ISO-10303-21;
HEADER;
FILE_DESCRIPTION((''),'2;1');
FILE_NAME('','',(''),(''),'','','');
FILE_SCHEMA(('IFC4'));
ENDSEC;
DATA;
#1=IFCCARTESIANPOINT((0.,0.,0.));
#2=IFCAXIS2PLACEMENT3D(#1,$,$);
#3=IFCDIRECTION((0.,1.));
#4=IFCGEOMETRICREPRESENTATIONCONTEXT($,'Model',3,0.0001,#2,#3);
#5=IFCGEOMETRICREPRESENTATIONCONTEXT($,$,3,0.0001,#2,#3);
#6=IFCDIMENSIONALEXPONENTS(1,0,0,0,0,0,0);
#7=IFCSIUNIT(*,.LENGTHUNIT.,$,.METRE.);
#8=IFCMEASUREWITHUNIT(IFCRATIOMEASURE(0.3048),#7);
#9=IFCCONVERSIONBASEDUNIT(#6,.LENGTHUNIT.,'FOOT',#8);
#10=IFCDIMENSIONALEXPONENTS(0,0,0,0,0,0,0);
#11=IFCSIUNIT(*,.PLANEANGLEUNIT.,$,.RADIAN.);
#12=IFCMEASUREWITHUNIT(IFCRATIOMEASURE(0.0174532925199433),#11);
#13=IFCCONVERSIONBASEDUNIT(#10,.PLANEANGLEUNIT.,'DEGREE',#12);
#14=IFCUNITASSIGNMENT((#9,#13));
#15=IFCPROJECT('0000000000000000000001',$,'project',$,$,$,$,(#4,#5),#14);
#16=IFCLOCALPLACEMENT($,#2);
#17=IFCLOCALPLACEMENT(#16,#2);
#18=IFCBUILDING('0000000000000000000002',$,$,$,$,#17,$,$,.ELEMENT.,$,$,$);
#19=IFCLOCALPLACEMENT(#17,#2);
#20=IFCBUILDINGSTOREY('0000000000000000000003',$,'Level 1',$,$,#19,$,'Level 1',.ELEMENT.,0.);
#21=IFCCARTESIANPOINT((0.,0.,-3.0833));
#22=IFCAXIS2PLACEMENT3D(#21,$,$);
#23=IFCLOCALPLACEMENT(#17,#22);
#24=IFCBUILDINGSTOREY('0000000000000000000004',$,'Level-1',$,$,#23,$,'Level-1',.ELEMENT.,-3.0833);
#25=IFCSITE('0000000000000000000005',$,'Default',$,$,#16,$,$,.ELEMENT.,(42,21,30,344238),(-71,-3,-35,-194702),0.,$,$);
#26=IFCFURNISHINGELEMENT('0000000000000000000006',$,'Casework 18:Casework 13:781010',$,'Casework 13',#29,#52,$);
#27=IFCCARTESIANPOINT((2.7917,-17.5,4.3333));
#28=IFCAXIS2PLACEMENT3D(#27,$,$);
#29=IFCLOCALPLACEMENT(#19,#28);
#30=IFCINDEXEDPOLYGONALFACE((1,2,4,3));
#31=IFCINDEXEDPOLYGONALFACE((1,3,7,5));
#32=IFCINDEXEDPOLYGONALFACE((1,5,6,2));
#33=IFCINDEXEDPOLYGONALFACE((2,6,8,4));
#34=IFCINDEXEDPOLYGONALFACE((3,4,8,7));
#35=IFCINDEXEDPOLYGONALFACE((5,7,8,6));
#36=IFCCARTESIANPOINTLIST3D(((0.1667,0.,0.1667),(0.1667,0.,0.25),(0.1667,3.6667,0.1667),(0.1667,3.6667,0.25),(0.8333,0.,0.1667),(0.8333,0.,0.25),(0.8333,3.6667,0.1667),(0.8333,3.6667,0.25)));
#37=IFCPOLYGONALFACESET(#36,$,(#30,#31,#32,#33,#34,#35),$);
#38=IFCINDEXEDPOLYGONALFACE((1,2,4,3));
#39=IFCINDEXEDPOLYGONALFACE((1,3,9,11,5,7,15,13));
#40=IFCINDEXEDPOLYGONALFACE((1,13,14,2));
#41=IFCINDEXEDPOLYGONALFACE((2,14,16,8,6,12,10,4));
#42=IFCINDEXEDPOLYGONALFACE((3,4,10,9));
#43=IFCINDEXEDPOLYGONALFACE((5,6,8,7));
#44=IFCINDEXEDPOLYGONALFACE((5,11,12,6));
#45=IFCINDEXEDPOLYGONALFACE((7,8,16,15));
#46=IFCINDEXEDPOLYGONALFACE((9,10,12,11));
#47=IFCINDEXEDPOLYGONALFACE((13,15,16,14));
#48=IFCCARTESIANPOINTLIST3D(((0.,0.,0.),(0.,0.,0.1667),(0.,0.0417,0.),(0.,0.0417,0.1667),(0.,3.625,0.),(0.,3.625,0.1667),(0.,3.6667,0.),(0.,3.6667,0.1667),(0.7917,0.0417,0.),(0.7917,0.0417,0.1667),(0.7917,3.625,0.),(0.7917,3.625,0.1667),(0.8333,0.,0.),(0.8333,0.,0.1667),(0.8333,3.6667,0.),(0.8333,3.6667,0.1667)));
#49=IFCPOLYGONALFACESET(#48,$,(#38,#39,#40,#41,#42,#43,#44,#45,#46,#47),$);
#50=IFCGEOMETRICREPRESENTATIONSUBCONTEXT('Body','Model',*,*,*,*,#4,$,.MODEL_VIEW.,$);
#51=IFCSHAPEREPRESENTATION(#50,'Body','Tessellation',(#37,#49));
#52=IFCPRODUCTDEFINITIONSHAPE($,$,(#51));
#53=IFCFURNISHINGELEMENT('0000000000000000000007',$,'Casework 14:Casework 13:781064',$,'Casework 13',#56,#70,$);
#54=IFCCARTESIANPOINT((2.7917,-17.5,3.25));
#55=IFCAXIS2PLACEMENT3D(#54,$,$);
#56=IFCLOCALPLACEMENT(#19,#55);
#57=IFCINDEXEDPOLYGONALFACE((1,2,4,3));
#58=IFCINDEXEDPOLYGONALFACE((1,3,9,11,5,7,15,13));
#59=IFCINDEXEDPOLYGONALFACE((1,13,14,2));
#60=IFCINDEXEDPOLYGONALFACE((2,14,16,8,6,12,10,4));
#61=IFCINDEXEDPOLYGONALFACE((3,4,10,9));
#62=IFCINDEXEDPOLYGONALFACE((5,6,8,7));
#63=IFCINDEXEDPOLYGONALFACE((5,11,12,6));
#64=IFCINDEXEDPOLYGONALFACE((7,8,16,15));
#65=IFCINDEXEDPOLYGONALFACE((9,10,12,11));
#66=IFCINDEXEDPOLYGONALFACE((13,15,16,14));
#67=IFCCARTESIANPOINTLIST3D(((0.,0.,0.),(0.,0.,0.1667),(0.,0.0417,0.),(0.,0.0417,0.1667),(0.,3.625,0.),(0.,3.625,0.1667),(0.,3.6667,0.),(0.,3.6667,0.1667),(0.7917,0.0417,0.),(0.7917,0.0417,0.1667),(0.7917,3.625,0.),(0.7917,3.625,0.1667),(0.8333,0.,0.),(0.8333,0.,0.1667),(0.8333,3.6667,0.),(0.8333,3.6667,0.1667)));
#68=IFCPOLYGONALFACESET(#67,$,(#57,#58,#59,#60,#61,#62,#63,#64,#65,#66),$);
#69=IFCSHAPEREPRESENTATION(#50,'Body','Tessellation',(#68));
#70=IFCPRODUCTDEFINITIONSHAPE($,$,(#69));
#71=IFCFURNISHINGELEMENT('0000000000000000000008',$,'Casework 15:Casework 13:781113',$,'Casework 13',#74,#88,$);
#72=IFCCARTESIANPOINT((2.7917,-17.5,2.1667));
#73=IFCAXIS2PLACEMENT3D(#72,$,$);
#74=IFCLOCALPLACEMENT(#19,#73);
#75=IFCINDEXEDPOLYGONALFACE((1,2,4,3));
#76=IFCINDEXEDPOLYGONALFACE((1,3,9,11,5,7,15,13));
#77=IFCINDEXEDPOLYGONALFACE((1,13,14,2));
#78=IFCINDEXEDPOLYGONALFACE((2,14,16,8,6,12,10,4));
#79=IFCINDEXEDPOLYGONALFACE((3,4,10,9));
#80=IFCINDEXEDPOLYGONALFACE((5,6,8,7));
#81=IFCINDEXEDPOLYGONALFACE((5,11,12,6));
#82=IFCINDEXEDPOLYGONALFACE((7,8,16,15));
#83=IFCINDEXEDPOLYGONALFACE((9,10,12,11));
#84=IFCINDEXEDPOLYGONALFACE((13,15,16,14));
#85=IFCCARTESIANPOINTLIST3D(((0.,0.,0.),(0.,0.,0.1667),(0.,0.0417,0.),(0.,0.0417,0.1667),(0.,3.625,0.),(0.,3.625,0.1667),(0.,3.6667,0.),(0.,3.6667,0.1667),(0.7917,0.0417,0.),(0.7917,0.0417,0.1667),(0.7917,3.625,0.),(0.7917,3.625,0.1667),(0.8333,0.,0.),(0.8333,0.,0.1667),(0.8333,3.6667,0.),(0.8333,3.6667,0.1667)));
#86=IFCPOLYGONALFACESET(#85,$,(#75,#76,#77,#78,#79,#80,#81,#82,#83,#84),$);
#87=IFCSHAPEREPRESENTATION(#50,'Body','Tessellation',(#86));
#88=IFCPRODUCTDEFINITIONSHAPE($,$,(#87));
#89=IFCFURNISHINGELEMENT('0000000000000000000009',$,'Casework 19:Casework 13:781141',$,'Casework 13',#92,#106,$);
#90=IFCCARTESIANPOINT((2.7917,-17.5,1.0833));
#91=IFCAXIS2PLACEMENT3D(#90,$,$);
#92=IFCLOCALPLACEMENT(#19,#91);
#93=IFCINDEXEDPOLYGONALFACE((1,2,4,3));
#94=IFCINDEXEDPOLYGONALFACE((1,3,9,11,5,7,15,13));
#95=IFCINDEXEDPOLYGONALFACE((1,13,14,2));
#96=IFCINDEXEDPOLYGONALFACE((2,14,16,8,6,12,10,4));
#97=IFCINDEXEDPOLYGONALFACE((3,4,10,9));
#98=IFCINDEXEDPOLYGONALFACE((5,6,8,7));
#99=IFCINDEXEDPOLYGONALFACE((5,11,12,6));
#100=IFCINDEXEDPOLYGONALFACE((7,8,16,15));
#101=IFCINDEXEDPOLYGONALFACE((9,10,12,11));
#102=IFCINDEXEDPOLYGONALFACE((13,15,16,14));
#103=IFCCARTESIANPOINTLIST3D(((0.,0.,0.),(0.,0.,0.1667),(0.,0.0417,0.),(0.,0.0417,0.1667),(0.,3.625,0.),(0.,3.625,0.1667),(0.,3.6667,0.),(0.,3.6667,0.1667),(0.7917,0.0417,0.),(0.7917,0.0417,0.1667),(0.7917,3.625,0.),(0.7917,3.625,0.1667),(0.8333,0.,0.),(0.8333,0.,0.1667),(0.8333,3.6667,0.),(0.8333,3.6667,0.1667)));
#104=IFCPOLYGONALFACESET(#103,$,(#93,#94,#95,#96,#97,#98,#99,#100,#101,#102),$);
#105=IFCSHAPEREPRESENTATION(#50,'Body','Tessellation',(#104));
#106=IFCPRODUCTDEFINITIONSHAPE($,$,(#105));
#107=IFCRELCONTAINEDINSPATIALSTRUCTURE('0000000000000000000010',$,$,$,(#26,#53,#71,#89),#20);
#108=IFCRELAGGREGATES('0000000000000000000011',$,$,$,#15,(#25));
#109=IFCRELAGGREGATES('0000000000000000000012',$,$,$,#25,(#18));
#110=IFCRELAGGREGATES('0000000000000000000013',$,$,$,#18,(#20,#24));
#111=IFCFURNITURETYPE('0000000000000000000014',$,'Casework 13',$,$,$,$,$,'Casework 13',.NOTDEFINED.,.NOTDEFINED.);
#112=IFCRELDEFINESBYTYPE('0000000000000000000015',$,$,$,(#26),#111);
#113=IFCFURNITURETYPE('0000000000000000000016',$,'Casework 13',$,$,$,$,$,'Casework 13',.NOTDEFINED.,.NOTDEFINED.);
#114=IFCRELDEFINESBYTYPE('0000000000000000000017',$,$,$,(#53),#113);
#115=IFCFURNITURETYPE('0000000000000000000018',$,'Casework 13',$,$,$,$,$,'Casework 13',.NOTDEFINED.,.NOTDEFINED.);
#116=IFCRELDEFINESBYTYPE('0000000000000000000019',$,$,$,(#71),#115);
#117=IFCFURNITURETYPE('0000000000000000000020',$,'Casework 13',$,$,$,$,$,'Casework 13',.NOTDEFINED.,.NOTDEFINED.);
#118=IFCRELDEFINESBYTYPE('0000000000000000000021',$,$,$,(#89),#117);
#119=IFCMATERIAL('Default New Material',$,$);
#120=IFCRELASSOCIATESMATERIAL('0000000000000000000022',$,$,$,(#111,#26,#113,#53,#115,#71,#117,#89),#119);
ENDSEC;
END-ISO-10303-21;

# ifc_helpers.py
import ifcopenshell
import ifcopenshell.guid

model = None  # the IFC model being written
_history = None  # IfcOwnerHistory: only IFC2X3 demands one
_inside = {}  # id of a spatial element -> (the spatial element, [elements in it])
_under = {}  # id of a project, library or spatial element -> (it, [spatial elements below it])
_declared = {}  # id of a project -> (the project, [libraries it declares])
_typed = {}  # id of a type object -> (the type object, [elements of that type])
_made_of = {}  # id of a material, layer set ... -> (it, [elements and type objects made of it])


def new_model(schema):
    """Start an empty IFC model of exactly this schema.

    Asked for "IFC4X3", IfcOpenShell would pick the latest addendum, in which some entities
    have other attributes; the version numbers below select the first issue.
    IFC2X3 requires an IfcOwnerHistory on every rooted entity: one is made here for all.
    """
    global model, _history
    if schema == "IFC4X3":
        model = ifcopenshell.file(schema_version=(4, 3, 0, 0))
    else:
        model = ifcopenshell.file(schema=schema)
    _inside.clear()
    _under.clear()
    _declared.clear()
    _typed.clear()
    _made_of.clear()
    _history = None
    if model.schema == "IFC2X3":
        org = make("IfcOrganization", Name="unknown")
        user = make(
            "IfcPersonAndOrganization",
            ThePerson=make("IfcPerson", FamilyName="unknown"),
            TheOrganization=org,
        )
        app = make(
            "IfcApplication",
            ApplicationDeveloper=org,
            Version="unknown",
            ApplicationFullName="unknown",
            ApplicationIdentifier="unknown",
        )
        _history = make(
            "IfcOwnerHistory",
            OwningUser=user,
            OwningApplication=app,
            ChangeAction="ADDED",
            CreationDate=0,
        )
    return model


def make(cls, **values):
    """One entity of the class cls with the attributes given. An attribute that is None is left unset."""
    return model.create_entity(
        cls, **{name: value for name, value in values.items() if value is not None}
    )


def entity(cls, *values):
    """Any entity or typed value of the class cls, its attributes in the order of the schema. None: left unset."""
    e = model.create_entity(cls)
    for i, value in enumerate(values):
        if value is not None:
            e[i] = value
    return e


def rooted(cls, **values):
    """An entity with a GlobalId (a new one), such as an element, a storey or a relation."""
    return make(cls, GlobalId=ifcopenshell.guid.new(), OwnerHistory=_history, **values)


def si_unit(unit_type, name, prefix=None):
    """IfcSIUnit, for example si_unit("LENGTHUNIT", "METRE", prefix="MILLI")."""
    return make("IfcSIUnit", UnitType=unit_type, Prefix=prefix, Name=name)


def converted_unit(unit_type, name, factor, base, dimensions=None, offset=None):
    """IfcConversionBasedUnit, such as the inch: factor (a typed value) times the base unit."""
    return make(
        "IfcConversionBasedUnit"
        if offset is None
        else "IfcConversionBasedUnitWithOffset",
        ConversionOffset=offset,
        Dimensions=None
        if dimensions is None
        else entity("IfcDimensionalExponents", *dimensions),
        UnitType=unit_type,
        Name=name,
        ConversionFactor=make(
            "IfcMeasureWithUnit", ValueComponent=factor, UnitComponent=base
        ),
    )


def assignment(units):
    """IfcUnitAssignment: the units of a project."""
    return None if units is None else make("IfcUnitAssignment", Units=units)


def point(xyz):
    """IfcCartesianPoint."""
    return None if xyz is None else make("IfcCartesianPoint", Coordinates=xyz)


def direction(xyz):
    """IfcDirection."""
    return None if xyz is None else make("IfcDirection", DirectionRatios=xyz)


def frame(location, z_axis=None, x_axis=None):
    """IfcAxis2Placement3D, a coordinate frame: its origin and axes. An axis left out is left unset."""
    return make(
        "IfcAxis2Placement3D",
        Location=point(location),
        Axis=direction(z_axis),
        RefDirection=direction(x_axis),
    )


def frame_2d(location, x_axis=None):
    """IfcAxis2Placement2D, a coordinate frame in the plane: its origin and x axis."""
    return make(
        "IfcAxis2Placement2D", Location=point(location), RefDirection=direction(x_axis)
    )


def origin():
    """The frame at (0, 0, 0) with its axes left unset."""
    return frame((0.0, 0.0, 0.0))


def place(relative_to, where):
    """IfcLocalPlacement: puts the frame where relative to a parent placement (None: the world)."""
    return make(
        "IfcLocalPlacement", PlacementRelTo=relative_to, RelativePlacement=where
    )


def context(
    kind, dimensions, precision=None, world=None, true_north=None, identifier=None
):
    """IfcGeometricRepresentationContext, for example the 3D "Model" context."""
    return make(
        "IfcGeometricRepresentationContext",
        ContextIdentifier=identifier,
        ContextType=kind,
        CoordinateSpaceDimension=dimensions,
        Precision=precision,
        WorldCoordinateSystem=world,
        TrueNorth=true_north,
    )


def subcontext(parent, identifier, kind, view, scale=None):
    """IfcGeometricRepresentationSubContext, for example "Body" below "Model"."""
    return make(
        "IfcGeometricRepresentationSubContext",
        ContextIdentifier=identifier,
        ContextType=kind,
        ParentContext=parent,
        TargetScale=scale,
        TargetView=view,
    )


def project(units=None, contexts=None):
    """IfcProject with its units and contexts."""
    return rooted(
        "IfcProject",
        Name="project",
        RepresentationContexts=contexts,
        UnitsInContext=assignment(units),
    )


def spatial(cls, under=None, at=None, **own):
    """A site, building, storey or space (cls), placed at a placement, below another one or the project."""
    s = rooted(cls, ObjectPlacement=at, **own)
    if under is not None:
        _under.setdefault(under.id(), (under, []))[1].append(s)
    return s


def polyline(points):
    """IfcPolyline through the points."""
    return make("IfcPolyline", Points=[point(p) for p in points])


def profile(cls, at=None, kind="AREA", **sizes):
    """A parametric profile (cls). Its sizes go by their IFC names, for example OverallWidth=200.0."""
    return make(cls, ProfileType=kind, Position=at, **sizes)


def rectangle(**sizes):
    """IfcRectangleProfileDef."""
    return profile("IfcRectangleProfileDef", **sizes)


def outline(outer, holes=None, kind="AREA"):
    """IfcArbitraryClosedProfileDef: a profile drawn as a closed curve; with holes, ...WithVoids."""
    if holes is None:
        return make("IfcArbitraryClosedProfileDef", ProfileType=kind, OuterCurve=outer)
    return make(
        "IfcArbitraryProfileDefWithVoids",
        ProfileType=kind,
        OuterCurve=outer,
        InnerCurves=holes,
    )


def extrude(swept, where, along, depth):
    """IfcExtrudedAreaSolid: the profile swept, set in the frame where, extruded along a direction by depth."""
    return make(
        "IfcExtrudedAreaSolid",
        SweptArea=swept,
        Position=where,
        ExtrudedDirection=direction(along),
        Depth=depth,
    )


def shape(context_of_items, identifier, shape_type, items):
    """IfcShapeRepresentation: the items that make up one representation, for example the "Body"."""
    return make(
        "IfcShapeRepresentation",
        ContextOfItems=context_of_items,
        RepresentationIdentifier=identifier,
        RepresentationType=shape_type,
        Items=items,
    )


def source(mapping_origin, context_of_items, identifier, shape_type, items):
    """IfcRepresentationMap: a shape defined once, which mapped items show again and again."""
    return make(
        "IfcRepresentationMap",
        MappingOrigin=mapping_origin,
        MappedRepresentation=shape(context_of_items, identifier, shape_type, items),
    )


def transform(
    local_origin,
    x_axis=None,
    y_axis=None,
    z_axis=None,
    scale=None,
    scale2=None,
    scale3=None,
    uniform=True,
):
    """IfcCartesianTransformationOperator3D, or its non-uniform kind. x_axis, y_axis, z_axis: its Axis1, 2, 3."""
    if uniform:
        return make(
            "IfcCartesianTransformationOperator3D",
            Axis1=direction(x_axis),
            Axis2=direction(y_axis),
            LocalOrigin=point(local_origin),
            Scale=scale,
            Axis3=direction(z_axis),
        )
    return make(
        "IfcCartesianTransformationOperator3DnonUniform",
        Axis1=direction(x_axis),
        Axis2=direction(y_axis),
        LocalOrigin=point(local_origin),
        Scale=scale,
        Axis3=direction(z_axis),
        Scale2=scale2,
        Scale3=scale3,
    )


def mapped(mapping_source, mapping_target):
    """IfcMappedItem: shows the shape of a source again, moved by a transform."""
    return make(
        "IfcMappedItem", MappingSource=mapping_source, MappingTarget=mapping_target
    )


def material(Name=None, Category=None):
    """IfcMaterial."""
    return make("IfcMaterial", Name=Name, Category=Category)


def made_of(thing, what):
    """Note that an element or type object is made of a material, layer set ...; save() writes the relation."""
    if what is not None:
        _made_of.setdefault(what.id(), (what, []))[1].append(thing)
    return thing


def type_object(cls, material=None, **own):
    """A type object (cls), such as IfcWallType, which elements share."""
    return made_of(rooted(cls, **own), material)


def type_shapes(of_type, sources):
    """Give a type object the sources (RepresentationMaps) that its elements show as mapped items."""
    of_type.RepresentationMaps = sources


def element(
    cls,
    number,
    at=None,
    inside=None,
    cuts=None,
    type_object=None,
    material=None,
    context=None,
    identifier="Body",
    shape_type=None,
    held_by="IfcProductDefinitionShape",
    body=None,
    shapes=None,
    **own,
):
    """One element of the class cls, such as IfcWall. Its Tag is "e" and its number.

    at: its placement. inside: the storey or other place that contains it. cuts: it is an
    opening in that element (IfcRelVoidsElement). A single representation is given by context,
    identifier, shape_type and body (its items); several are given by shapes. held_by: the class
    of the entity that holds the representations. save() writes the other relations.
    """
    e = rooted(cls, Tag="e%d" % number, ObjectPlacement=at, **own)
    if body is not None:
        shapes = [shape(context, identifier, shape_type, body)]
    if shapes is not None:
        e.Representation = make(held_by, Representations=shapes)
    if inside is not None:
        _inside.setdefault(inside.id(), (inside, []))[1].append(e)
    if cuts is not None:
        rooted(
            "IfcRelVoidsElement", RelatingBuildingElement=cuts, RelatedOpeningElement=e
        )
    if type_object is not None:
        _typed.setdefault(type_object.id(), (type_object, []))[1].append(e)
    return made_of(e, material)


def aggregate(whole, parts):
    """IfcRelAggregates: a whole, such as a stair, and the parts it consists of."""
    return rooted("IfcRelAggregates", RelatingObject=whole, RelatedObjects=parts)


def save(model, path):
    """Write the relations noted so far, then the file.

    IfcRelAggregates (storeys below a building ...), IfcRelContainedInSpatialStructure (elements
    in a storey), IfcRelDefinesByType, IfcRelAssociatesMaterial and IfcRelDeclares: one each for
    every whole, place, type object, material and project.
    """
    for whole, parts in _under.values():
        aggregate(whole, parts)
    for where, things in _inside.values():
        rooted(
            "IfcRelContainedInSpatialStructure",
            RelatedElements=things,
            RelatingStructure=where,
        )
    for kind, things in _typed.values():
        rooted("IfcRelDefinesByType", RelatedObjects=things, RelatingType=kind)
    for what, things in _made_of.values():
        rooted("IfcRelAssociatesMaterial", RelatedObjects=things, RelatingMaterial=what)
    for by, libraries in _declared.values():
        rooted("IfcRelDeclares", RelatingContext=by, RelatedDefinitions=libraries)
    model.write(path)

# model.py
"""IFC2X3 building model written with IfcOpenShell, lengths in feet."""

from ifc_helpers import new_model, entity, si_unit, converted_unit, direction, frame, frame_2d, origin, place, context, subcontext, project, spatial, polyline, rectangle, outline, extrude, source, transform, mapped, material, type_object, type_shapes, element, save


model = new_model("IFC2X3")

# Units and contexts
model_context = context("Model", 3, precision=0.0001, world=origin(), true_north=direction((0.0, 1.0)))
context_of_model = context(None, 3, precision=0.0001, world=origin(), true_north=direction((0.0, 1.0)))
body_context = subcontext(model_context, "Body", "Model", "MODEL_VIEW")
ifc_project = project(units=[converted_unit("LENGTHUNIT", "FOOT", entity("IfcRatioMeasure", 0.3048), si_unit("LENGTHUNIT", "METRE"), dimensions=[1, 0, 0, 0, 0, 0, 0]), converted_unit("PLANEANGLEUNIT", "DEGREE", entity("IfcRatioMeasure", 0.0174532925199433), si_unit("PLANEANGLEUNIT", "RADIAN"), dimensions=[0, 0, 0, 0, 0, 0, 0])], contexts=[model_context, context_of_model])

# Site, building, storey
site_placement = place(None, origin())
site = spatial("IfcSite", under=ifc_project, at=site_placement, Name="Default", CompositionType="ELEMENT", RefLatitude=(42, 21, 30, 344238), RefLongitude=(-71, -3, -35, -194702), RefElevation=0.0)
building_placement = place(site_placement, origin())
building = spatial("IfcBuilding", under=site, at=building_placement, CompositionType="ELEMENT")
storey_1_placement = place(building_placement, origin())
storey_1 = spatial("IfcBuildingStorey", under=building, at=storey_1_placement, Name="Level 1", LongName="Level 1", CompositionType="ELEMENT", Elevation=0.0)

# Shared definitions
ifc_material_1 = material(Name="Default New Material")

# Shared definitions
storey_2_placement = place(building_placement, frame((0.0, 0.0, -3.0833)))
storey_2 = spatial("IfcBuildingStorey", under=building, at=storey_2_placement, Name="Level-1", LongName="Level-1", CompositionType="ELEMENT", Elevation=-3.0833)

# Furnishing elements
furniture_type_1 = type_object("IfcFurnitureType", Name="Casework 13", ElementType="Casework 13", AssemblyPlace="NOTDEFINED", material=ifc_material_1)
shared_shape_1 = source(origin(), body_context, "Body", "SweptSolid", [
    extrude(rectangle(XDim=0.6667, YDim=3.6667, at=frame_2d((0.0, 0.0), x_axis=(1.0, 0.0))), frame((0.5, 1.8333, 0.1667)), (0.0, 0.0, 1.0), 0.0833),
    extrude(outline(polyline([(-0.4063, -1.7917), (-0.4063, -1.8333), (0.4271, -1.8333), (0.4271, 1.8333), (-0.4062, 1.8333), (-0.4062, 1.7917), (0.3854, 1.7917), (0.3854, -1.7917), (-0.4063, -1.7917)])), frame((0.4063, 1.8333, 0.0), z_axis=(0.0, 0.0, -1.0), x_axis=(1.0, 0.0, 0.0)), (0.0, 0.0, -1.0), 0.1667),
])
type_shapes(furniture_type_1, [shared_shape_1])
furnishing_1_placement = place(storey_1_placement, frame((2.7917, -17.5, 4.3333)))
element("IfcFurnishingElement", 1, at=furnishing_1_placement, inside=storey_1, type_object=furniture_type_1, material=ifc_material_1, Name="Casework 18:Casework 13:781010", ObjectType="Casework 13", context=body_context, shape_type="MappedRepresentation", body=[
    mapped(shared_shape_1, transform((0.0, 0.0, 0.0), scale=1.0)),
])
furniture_type_2 = type_object("IfcFurnitureType", Name="Casework 13", ElementType="Casework 13", AssemblyPlace="NOTDEFINED", material=ifc_material_1)
shared_shape_2 = source(origin(), body_context, "Body", "SweptSolid", [
    extrude(outline(polyline([(-0.4063, -1.7917), (-0.4063, -1.8333), (0.4271, -1.8333), (0.4271, 1.8333), (-0.4062, 1.8333), (-0.4062, 1.7917), (0.3854, 1.7917), (0.3854, -1.7917), (-0.4063, -1.7917)])), frame((0.4062, 1.8333, 0.0), z_axis=(0.0, 0.0, -1.0), x_axis=(1.0, 0.0, 0.0)), (0.0, 0.0, -1.0), 0.1667),
])
type_shapes(furniture_type_2, [shared_shape_2])
furnishing_2_placement = place(storey_1_placement, frame((2.7917, -17.5, 3.25)))
element("IfcFurnishingElement", 2, at=furnishing_2_placement, inside=storey_1, type_object=furniture_type_2, material=ifc_material_1, Name="Casework 14:Casework 13:781064", ObjectType="Casework 13", context=body_context, shape_type="MappedRepresentation", body=[
    mapped(shared_shape_2, transform((0.0, 0.0, 0.0), scale=1.0)),
])
furniture_type_3 = type_object("IfcFurnitureType", Name="Casework 13", ElementType="Casework 13", AssemblyPlace="NOTDEFINED", material=ifc_material_1)
shared_shape_3 = source(origin(), body_context, "Body", "SweptSolid", [
    extrude(outline(polyline([(-0.4063, -1.7917), (-0.4063, -1.8333), (0.4271, -1.8333), (0.4271, 1.8333), (-0.4062, 1.8333), (-0.4062, 1.7917), (0.3854, 1.7917), (0.3854, -1.7917), (-0.4063, -1.7917)])), frame((0.4062, 1.8333, 0.0), z_axis=(0.0, 0.0, -1.0), x_axis=(1.0, 0.0, 0.0)), (0.0, 0.0, -1.0), 0.1667),
])
type_shapes(furniture_type_3, [shared_shape_3])
furnishing_3_placement = place(storey_1_placement, frame((2.7917, -17.5, 2.1667)))
element("IfcFurnishingElement", 3, at=furnishing_3_placement, inside=storey_1, type_object=furniture_type_3, material=ifc_material_1, Name="Casework 15:Casework 13:781113", ObjectType="Casework 13", context=body_context, shape_type="MappedRepresentation", body=[
    mapped(shared_shape_3, transform((0.0, 0.0, 0.0), scale=1.0)),
])
furniture_type_4 = type_object("IfcFurnitureType", Name="Casework 13", ElementType="Casework 13", AssemblyPlace="NOTDEFINED", material=ifc_material_1)
shared_shape_4 = source(origin(), body_context, "Body", "SweptSolid", [
    extrude(outline(polyline([(-0.4063, -1.7917), (-0.4063, -1.8333), (0.4271, -1.8333), (0.4271, 1.8333), (-0.4062, 1.8333), (-0.4062, 1.7917), (0.3854, 1.7917), (0.3854, -1.7917), (-0.4063, -1.7917)])), frame((0.4062, 1.8333, 0.0), z_axis=(0.0, 0.0, -1.0), x_axis=(1.0, 0.0, 0.0)), (0.0, 0.0, -1.0), 0.1667),
])
type_shapes(furniture_type_4, [shared_shape_4])
furnishing_4_placement = place(storey_1_placement, frame((2.7917, -17.5, 1.0833)))
element("IfcFurnishingElement", 4, at=furnishing_4_placement, inside=storey_1, type_object=furniture_type_4, material=ifc_material_1, Name="Casework 19:Casework 13:781141", ObjectType="Casework 13", context=body_context, shape_type="MappedRepresentation", body=[
    mapped(shared_shape_4, transform((0.0, 0.0, 0.0), scale=1.0)),
])

save(model, "model.ifc")
